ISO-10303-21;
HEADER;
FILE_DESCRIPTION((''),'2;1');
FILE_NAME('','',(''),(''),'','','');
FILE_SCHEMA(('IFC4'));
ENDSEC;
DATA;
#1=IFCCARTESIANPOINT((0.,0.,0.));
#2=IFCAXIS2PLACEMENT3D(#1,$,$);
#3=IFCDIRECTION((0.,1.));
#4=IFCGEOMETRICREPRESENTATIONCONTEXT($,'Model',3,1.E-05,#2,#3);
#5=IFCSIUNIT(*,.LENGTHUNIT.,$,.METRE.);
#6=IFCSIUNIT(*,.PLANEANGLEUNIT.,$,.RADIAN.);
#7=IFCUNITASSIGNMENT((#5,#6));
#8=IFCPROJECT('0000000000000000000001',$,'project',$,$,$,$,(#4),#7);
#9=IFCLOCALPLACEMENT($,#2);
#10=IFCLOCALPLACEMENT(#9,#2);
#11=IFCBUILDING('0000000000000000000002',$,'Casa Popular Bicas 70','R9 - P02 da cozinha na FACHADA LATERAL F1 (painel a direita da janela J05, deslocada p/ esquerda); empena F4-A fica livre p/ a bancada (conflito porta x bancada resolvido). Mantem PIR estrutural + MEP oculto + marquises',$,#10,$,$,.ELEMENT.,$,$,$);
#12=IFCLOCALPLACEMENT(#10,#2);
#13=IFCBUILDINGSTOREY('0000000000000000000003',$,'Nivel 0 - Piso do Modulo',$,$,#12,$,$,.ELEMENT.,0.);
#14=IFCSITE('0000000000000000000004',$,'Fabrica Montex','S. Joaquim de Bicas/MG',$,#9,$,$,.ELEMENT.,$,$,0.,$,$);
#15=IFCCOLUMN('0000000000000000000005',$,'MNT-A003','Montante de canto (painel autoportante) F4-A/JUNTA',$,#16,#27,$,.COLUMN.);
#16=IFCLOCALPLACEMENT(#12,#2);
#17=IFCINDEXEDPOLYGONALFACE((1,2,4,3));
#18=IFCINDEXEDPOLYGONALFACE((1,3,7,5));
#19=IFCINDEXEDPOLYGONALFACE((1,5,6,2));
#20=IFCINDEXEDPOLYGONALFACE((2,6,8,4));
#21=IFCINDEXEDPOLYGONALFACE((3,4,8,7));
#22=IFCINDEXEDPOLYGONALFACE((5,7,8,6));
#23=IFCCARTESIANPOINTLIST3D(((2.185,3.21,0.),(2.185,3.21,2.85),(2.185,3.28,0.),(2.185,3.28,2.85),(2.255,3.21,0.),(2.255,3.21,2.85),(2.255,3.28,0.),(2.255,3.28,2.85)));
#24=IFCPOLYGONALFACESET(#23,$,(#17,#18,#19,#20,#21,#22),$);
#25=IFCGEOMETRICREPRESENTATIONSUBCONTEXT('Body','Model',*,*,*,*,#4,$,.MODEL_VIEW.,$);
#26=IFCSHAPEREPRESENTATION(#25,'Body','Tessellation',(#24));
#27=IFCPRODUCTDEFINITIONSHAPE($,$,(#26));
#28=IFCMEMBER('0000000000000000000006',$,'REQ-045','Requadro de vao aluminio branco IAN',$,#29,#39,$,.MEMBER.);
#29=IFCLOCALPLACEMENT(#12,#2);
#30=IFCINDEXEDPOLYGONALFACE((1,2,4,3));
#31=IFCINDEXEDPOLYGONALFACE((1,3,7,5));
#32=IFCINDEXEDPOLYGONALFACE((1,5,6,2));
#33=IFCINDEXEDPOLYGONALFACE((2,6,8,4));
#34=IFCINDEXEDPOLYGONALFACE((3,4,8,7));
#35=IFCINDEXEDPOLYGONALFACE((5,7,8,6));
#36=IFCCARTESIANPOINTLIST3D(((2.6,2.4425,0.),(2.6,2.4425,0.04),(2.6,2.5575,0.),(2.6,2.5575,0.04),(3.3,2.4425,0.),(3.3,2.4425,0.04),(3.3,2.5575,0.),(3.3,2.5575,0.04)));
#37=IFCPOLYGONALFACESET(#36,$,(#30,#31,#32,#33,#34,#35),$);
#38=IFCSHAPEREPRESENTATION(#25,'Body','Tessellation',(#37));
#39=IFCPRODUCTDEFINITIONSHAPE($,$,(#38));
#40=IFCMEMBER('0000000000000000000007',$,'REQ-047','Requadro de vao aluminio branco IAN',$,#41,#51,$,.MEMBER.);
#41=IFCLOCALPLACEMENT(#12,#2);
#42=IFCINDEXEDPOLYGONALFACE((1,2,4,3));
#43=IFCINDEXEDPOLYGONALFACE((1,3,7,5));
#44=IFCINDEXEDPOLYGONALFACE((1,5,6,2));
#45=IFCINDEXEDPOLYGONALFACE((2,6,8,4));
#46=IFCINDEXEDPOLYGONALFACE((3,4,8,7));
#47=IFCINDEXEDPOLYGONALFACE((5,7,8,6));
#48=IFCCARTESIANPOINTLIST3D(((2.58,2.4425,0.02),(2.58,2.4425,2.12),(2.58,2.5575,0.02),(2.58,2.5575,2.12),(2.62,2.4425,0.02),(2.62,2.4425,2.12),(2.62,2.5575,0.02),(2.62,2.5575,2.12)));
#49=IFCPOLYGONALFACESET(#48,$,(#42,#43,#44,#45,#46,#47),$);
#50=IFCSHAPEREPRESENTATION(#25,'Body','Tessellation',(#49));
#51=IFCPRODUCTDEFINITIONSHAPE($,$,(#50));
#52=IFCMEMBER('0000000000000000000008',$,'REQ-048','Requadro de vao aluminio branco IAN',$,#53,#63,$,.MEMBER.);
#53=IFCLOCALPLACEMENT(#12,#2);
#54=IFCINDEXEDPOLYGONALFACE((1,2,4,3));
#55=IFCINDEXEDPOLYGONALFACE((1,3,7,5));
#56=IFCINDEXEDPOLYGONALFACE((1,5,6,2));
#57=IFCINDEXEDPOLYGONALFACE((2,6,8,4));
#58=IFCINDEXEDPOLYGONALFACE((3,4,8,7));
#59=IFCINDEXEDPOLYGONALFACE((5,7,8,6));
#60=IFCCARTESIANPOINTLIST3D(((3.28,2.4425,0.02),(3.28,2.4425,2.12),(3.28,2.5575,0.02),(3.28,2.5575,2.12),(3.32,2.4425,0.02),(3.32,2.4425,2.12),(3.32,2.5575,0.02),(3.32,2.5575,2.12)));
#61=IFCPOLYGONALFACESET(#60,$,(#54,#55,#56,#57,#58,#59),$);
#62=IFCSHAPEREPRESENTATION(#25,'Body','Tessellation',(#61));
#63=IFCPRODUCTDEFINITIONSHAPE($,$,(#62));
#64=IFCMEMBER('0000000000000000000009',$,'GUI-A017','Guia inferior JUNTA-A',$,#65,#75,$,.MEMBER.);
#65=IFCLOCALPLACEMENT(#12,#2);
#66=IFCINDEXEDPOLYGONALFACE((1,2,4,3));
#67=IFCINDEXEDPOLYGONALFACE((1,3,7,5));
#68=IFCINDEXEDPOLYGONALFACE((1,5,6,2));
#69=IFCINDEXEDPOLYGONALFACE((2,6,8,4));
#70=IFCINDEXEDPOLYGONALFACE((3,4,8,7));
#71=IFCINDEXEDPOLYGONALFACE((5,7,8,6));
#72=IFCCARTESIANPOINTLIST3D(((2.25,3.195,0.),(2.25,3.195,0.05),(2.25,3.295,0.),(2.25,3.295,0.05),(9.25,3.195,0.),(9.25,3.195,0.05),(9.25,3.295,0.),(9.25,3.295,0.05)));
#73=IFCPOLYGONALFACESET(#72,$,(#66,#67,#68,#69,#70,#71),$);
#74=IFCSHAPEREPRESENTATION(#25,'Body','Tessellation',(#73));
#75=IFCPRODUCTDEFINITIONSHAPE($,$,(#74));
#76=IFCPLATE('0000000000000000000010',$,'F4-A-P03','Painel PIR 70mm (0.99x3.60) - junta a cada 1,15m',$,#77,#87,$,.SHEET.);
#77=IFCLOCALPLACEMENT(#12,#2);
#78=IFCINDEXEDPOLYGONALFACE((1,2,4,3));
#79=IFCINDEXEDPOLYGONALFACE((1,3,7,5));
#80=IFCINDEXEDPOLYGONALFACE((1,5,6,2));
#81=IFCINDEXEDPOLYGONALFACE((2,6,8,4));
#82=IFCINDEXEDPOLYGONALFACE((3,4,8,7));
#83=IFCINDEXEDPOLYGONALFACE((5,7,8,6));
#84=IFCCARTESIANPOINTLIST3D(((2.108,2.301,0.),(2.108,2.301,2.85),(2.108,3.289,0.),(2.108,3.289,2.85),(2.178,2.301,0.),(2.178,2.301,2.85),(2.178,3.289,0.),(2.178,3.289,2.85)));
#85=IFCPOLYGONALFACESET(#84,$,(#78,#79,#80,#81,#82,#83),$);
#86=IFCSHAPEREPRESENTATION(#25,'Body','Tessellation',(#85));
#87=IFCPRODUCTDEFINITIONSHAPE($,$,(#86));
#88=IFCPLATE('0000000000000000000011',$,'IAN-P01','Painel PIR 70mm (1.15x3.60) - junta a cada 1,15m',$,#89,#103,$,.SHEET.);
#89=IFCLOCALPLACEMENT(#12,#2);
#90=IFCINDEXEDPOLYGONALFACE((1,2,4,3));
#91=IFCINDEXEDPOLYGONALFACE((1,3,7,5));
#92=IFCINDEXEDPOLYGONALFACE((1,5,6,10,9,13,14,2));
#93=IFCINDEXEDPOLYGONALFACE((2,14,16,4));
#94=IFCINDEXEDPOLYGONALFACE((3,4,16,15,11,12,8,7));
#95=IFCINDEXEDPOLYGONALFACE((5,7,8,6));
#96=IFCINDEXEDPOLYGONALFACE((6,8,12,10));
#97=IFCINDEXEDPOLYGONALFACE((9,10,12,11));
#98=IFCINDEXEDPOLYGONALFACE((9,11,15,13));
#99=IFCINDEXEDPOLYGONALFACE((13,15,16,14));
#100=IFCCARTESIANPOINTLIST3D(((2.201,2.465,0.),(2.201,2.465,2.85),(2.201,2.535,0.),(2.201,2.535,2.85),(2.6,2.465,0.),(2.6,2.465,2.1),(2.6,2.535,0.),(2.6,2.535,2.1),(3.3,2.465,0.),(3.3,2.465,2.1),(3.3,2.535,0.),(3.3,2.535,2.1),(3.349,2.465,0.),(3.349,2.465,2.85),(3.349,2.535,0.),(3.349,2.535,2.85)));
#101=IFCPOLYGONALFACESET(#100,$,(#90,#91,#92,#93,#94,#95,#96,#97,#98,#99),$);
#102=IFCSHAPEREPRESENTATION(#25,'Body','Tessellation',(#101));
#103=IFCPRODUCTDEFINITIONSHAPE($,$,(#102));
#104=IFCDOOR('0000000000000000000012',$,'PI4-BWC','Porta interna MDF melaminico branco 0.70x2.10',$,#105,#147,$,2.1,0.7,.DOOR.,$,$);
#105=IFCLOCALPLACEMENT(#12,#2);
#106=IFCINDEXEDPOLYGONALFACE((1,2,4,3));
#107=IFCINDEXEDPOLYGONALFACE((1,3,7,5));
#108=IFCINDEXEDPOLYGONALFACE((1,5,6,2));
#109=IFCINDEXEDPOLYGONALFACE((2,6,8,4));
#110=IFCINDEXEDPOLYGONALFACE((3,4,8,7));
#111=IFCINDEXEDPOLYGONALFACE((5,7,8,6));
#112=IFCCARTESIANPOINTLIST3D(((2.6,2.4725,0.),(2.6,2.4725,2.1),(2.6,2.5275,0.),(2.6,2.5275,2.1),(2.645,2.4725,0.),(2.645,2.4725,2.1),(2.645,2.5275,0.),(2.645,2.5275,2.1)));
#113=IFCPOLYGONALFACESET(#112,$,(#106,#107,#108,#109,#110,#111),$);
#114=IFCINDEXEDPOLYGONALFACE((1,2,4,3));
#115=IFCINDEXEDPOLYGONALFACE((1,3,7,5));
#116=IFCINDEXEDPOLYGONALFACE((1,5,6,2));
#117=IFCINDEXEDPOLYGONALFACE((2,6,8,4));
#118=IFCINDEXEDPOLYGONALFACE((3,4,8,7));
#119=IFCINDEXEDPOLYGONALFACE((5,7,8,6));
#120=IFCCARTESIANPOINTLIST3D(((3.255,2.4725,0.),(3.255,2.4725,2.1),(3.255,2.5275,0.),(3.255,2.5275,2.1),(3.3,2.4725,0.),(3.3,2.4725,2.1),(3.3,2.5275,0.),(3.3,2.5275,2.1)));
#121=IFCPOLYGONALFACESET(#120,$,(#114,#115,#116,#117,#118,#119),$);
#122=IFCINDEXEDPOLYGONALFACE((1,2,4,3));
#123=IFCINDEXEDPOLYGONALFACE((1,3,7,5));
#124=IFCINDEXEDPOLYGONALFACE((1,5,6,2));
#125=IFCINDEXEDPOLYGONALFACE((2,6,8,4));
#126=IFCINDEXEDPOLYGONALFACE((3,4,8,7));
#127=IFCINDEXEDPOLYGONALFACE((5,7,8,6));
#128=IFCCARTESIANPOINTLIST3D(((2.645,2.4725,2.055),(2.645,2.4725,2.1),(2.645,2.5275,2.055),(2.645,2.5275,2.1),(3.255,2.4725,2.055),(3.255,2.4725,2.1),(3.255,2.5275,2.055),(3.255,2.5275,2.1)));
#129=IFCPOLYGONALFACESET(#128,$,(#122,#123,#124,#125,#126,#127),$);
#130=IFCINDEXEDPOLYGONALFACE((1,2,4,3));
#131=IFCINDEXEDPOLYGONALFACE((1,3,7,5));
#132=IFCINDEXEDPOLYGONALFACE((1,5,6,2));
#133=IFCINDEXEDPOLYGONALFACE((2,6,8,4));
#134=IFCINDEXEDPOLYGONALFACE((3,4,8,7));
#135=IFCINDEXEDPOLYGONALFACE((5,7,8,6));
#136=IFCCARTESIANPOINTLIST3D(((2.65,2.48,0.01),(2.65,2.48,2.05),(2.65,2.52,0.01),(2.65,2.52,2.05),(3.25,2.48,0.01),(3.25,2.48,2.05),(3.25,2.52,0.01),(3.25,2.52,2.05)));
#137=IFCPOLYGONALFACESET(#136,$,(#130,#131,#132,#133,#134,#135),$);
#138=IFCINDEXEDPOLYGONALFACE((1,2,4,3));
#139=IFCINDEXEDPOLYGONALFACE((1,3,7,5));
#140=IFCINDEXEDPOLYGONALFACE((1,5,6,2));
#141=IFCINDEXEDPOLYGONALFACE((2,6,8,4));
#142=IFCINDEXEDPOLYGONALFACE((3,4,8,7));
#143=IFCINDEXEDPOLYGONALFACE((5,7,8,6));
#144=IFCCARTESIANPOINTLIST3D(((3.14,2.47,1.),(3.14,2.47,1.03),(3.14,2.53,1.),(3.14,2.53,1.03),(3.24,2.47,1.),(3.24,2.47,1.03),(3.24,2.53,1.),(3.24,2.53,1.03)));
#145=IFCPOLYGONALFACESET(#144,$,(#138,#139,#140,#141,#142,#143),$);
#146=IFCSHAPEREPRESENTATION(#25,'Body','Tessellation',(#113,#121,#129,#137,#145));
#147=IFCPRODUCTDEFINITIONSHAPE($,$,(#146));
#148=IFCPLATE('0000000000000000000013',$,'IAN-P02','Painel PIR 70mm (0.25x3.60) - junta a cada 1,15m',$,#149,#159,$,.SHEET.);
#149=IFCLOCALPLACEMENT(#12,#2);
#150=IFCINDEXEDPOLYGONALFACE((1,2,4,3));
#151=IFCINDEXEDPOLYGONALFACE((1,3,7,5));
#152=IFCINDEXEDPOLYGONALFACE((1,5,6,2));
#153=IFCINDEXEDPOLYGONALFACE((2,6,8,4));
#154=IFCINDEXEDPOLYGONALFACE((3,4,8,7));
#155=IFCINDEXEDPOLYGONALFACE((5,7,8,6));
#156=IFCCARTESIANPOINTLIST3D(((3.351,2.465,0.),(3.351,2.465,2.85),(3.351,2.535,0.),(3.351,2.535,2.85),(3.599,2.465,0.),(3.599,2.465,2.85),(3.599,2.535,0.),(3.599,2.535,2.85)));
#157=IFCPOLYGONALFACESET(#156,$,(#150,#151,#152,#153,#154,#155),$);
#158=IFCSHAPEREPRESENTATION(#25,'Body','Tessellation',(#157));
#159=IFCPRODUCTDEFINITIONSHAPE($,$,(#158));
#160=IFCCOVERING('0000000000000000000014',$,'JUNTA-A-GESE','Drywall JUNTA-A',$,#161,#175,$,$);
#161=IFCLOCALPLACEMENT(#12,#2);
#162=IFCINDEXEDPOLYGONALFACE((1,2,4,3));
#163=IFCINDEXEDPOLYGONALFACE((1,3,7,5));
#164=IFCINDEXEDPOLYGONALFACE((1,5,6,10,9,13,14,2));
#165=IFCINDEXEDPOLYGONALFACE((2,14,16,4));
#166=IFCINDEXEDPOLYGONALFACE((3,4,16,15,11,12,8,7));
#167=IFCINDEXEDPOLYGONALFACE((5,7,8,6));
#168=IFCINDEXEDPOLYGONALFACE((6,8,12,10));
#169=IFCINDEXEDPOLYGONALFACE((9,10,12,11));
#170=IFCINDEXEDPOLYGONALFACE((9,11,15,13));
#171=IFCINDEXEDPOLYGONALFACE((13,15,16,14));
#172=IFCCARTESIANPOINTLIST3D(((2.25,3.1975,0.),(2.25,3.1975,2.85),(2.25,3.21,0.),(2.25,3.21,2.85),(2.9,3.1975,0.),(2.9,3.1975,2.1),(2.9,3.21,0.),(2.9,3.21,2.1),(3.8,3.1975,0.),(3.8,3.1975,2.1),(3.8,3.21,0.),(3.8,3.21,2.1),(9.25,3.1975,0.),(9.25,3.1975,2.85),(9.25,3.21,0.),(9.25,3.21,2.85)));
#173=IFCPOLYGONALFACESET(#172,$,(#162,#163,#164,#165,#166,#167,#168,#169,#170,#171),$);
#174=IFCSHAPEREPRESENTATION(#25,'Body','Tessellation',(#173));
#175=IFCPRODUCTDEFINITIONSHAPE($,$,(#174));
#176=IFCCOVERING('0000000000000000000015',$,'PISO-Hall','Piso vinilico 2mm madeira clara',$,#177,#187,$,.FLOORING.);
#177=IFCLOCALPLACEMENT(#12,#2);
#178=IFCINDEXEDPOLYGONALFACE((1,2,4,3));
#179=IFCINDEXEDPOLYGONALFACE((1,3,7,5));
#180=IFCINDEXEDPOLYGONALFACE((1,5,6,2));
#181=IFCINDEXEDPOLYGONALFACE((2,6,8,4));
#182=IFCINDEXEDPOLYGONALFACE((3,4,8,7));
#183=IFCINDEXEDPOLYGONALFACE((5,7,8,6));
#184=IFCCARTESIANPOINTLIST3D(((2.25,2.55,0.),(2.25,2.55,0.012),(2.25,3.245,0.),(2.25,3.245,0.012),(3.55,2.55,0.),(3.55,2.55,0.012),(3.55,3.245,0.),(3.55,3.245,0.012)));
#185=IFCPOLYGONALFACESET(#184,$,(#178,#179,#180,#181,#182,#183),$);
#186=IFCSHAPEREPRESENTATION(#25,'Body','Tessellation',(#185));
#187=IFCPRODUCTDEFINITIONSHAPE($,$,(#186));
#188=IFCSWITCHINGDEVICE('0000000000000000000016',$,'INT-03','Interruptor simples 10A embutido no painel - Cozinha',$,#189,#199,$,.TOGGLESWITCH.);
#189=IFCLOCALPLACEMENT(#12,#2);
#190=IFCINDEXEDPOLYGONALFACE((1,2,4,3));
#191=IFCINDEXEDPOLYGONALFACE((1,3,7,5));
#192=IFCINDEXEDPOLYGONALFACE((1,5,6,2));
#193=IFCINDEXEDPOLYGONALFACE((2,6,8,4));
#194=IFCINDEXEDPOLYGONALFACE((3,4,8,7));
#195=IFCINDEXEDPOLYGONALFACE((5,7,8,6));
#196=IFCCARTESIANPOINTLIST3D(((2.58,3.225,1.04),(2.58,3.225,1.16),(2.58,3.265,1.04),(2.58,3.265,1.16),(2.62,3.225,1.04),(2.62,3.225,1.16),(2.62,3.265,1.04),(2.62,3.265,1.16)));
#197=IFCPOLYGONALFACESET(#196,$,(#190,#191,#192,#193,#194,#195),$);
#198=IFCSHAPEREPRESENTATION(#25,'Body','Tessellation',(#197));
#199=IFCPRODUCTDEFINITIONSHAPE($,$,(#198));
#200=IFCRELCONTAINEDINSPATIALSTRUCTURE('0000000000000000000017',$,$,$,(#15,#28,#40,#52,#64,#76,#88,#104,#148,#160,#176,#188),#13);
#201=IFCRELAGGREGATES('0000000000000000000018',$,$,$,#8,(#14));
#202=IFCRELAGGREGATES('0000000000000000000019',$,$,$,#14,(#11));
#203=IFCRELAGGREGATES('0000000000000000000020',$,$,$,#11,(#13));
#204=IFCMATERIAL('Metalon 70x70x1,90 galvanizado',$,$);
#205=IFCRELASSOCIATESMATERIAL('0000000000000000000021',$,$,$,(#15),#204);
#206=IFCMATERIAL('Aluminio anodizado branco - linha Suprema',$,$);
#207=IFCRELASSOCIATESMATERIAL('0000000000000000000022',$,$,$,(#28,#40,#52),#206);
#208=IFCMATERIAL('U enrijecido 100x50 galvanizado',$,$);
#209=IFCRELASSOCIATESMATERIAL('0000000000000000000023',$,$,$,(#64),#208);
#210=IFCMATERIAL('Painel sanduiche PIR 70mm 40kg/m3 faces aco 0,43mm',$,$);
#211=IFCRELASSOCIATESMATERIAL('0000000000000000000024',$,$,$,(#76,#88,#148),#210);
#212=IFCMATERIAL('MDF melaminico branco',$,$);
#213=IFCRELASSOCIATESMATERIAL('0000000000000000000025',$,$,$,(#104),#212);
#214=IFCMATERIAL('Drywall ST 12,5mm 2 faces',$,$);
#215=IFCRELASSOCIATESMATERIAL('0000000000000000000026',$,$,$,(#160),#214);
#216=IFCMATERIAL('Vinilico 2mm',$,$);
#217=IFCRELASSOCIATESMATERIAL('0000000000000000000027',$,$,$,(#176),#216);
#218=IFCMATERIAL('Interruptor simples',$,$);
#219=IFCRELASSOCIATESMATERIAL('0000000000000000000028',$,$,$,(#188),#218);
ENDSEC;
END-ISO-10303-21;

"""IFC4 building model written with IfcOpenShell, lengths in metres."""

from ifc_helpers import new_model, si_unit, direction, frame, frame_2d, origin, origin_2d, place, context, subcontext, project, spatial, rectangle, extrude, material, element, fill, save


model = new_model("IFC4")

# Units and contexts
model_context = context("Model", 3, precision=1e-05, world=origin(), true_north=direction((0.0, 1.0)))
body_context = subcontext(model_context, "Body", "Model", "MODEL_VIEW")
ifc_project = project(units=[si_unit("LENGTHUNIT", "METRE"), si_unit("PLANEANGLEUNIT", "RADIAN")], contexts=[model_context])

# Site, building, storey
site_placement = place(None, origin())
site = spatial("IfcSite", under=ifc_project, at=site_placement, Name="Fabrica Montex", Description="S. Joaquim de Bicas/MG", CompositionType="ELEMENT", RefElevation=0.0)
building_placement = place(site_placement, origin())
building = spatial("IfcBuilding", under=site, at=building_placement, Name="Casa Popular Bicas 70", Description="R9 - P02 da cozinha na FACHADA LATERAL F1 (painel a direita da janela J05, deslocada p/ esquerda); empena F4-A fica livre p/ a bancada (conflito porta x bancada resolvido). Mantem PIR estrutural + MEP oculto + marquises", CompositionType="ELEMENT")
storey_placement = place(building_placement, origin())
storey = spatial("IfcBuildingStorey", under=building, at=storey_placement, Name="Nivel 0 - Piso do Modulo", CompositionType="ELEMENT", Elevation=0.0)

# Column
ifc_material_1 = material(Name="Metalon 70x70x1,90 galvanizado")
column_placement = place(storey_placement, frame((2.22, 3.245, 0.0)))
element("IfcColumn", 1, at=column_placement, inside=storey, material=ifc_material_1, Name="MNT-A003", Description="Montante de canto (painel autoportante) F4-A/JUNTA", PredefinedType="COLUMN", context=body_context, shape_type="SweptSolid", body=[
    extrude(rectangle(XDim=0.07, YDim=0.07, at=origin_2d()), origin(), (0.0, 0.0, 1.0), 2.85),
])

# Members
ifc_material_2 = material(Name="Aluminio anodizado branco - linha Suprema")
member_1_placement = place(storey_placement, frame((2.6, 2.5, 0.02), z_axis=(1.0, 0.0, 0.0), x_axis=(0.0, 0.0, 1.0)))
element("IfcMember", 2, at=member_1_placement, inside=storey, material=ifc_material_2, Name="REQ-045", Description="Requadro de vao aluminio branco IAN", PredefinedType="MEMBER", context=body_context, shape_type="SweptSolid", body=[
    extrude(rectangle(XDim=0.04, YDim=0.115, at=origin_2d()), origin(), (0.0, 0.0, 1.0), 0.7),
])
for number, where, z_axis, x_axis, name in (
    (3, (2.6, 2.5, 0.02), (0.0, 0.0, 1.0), (1.0, 0.0, 0.0), "REQ-047"),
    (4, (3.3, 2.5, 0.02), (0.0, 0.0, 1.0), (1.0, 0.0, 0.0), "REQ-048"),
):
    element("IfcMember", number, at=place(storey_placement, frame(where, z_axis=z_axis, x_axis=x_axis)), inside=storey, material=ifc_material_2, Name=name, Description="Requadro de vao aluminio branco IAN", PredefinedType="MEMBER", context=body_context, shape_type="SweptSolid", body=[
        extrude(rectangle(XDim=0.04, YDim=0.115, at=origin_2d()), origin(), (0.0, 0.0, 1.0), 2.1),
    ])
ifc_material_3 = material(Name="U enrijecido 100x50 galvanizado")
member_2_placement = place(storey_placement, frame((2.25, 3.245, 0.025), z_axis=(1.0, 0.0, 0.0), x_axis=(0.0, 0.0, 1.0)))
element("IfcMember", 5, at=member_2_placement, inside=storey, material=ifc_material_3, Name="GUI-A017", Description="Guia inferior JUNTA-A", PredefinedType="MEMBER", context=body_context, shape_type="SweptSolid", body=[
    extrude(rectangle(XDim=0.05, YDim=0.1, at=origin_2d()), origin(), (0.0, 0.0, 1.0), 7.0),
])

# Plate
ifc_material_4 = material(Name="Painel sanduiche PIR 70mm 40kg/m3 faces aco 0,43mm")
plate_1_placement = place(storey_placement, frame((2.143, 2.301, 0.0), x_axis=(0.0, 1.0, 0.0)))
element("IfcPlate", 6, at=plate_1_placement, inside=storey, material=ifc_material_4, Name="F4-A-P03", Description="Painel PIR 70mm (0.99x3.60) - junta a cada 1,15m", PredefinedType="SHEET", context=body_context, shape_type="SweptSolid", body=[
    extrude(rectangle(XDim=0.988, YDim=0.07, at=frame_2d((0.494, 0.0))), origin(), (0.0, 0.0, 1.0), 2.85),
])

# Plate, opening, door
plate_2_placement = place(storey_placement, frame((2.201, 2.5, 0.0), x_axis=(1.0, 0.0, 0.0)))
plate_2 = element("IfcPlate", 7, at=plate_2_placement, inside=storey, material=ifc_material_4, Name="IAN-P01", Description="Painel PIR 70mm (1.15x3.60) - junta a cada 1,15m", PredefinedType="SHEET", context=body_context, shape_type="SweptSolid", body=[
    extrude(rectangle(XDim=1.148, YDim=0.07, at=frame_2d((0.574, 0.0))), origin(), (0.0, 0.0, 1.0), 2.85),
])
opening_1_placement = place(storey_placement, frame((2.95, 2.5, 0.0)))
opening_1 = element("IfcOpeningElement", 8, at=opening_1_placement, cuts=plate_2, PredefinedType="OPENING", context=body_context, shape_type="SweptSolid", body=[
    extrude(rectangle(XDim=0.7, YDim=0.1, at=origin_2d()), origin(), (0.0, 0.0, 1.0), 2.1),
])
ifc_material_5 = material(Name="MDF melaminico branco")
door_placement = place(storey_placement, frame((2.6, 2.5, 0.0), x_axis=(1.0, 0.0, 0.0)))
door = element("IfcDoor", 9, at=door_placement, inside=storey, material=ifc_material_5, Name="PI4-BWC", Description="Porta interna MDF melaminico branco 0.70x2.10", OverallHeight=2.1, OverallWidth=0.7, PredefinedType="DOOR", context=body_context, shape_type="SweptSolid", body=[
    extrude(rectangle(XDim=0.045, YDim=0.055, at=frame_2d((0.0225, 0.0))), origin(), (0.0, 0.0, 1.0), 2.1),
    extrude(rectangle(XDim=0.045, YDim=0.055, at=frame_2d((0.6775, 0.0))), origin(), (0.0, 0.0, 1.0), 2.1),
    extrude(rectangle(XDim=0.61, YDim=0.055, at=frame_2d((0.35, 0.0))), frame((0.0, 0.0, 2.055)), (0.0, 0.0, 1.0), 0.045),
    extrude(rectangle(XDim=0.6, YDim=0.04, at=frame_2d((0.35, 0.0))), frame((0.0, 0.0, 0.01)), (0.0, 0.0, 1.0), 2.04),
    extrude(rectangle(XDim=0.1, YDim=0.06, at=frame_2d((0.59, 0.0))), frame((0.0, 0.0, 1.0)), (0.0, 0.0, 1.0), 0.03),
])
fill(opening_1, door)

# Plate
plate_3_placement = place(storey_placement, frame((3.351, 2.5, 0.0), x_axis=(1.0, 0.0, 0.0)))
element("IfcPlate", 10, at=plate_3_placement, inside=storey, material=ifc_material_4, Name="IAN-P02", Description="Painel PIR 70mm (0.25x3.60) - junta a cada 1,15m", PredefinedType="SHEET", context=body_context, shape_type="SweptSolid", body=[
    extrude(rectangle(XDim=0.248, YDim=0.07, at=frame_2d((0.124, 0.0))), origin(), (0.0, 0.0, 1.0), 2.85),
])

# Covering, opening
ifc_material_6 = material(Name="Drywall ST 12,5mm 2 faces")
covering_1_placement = place(storey_placement, frame((2.25, 3.2038, 0.0), x_axis=(1.0, 0.0, 0.0)))
covering_1 = element("IfcCovering", 11, at=covering_1_placement, inside=storey, material=ifc_material_6, Name="JUNTA-A-GESE", Description="Drywall JUNTA-A", context=body_context, shape_type="SweptSolid", body=[
    extrude(rectangle(XDim=7.0, YDim=0.0125, at=frame_2d((3.5, 0.0))), origin(), (0.0, 0.0, 1.0), 2.85),
])
opening_2_placement = place(storey_placement, frame((3.35, 3.2038, 0.0)))
element("IfcOpeningElement", 12, at=opening_2_placement, cuts=covering_1, PredefinedType="OPENING", context=body_context, shape_type="SweptSolid", body=[
    extrude(rectangle(XDim=0.9, YDim=0.0425, at=origin_2d()), origin(), (0.0, 0.0, 1.0), 2.1),
])

# Covering
ifc_material_7 = material(Name="Vinilico 2mm")
covering_2_placement = place(storey_placement, frame((2.25, 2.55, 0.0)))
element("IfcCovering", 13, at=covering_2_placement, inside=storey, material=ifc_material_7, Name="PISO-Hall", Description="Piso vinilico 2mm madeira clara", PredefinedType="FLOORING", context=body_context, shape_type="SweptSolid", body=[
    extrude(rectangle(XDim=1.3, YDim=0.695, at=frame_2d((0.65, 0.3475))), origin(), (0.0, 0.0, 1.0), 0.012),
])

# Switching device
ifc_material_8 = material(Name="Interruptor simples")
switching_device_placement = place(storey_placement, frame((2.58, 3.225, 1.04)))
element("IfcSwitchingDevice", 14, at=switching_device_placement, inside=storey, material=ifc_material_8, Name="INT-03", Description="Interruptor simples 10A embutido no painel - Cozinha", PredefinedType="TOGGLESWITCH", context=body_context, shape_type="SweptSolid", body=[
    extrude(rectangle(XDim=0.04, YDim=0.04, at=frame_2d((0.02, 0.02))), origin(), (0.0, 0.0, 1.0), 0.12),
])

save(model, "model.ifc")
